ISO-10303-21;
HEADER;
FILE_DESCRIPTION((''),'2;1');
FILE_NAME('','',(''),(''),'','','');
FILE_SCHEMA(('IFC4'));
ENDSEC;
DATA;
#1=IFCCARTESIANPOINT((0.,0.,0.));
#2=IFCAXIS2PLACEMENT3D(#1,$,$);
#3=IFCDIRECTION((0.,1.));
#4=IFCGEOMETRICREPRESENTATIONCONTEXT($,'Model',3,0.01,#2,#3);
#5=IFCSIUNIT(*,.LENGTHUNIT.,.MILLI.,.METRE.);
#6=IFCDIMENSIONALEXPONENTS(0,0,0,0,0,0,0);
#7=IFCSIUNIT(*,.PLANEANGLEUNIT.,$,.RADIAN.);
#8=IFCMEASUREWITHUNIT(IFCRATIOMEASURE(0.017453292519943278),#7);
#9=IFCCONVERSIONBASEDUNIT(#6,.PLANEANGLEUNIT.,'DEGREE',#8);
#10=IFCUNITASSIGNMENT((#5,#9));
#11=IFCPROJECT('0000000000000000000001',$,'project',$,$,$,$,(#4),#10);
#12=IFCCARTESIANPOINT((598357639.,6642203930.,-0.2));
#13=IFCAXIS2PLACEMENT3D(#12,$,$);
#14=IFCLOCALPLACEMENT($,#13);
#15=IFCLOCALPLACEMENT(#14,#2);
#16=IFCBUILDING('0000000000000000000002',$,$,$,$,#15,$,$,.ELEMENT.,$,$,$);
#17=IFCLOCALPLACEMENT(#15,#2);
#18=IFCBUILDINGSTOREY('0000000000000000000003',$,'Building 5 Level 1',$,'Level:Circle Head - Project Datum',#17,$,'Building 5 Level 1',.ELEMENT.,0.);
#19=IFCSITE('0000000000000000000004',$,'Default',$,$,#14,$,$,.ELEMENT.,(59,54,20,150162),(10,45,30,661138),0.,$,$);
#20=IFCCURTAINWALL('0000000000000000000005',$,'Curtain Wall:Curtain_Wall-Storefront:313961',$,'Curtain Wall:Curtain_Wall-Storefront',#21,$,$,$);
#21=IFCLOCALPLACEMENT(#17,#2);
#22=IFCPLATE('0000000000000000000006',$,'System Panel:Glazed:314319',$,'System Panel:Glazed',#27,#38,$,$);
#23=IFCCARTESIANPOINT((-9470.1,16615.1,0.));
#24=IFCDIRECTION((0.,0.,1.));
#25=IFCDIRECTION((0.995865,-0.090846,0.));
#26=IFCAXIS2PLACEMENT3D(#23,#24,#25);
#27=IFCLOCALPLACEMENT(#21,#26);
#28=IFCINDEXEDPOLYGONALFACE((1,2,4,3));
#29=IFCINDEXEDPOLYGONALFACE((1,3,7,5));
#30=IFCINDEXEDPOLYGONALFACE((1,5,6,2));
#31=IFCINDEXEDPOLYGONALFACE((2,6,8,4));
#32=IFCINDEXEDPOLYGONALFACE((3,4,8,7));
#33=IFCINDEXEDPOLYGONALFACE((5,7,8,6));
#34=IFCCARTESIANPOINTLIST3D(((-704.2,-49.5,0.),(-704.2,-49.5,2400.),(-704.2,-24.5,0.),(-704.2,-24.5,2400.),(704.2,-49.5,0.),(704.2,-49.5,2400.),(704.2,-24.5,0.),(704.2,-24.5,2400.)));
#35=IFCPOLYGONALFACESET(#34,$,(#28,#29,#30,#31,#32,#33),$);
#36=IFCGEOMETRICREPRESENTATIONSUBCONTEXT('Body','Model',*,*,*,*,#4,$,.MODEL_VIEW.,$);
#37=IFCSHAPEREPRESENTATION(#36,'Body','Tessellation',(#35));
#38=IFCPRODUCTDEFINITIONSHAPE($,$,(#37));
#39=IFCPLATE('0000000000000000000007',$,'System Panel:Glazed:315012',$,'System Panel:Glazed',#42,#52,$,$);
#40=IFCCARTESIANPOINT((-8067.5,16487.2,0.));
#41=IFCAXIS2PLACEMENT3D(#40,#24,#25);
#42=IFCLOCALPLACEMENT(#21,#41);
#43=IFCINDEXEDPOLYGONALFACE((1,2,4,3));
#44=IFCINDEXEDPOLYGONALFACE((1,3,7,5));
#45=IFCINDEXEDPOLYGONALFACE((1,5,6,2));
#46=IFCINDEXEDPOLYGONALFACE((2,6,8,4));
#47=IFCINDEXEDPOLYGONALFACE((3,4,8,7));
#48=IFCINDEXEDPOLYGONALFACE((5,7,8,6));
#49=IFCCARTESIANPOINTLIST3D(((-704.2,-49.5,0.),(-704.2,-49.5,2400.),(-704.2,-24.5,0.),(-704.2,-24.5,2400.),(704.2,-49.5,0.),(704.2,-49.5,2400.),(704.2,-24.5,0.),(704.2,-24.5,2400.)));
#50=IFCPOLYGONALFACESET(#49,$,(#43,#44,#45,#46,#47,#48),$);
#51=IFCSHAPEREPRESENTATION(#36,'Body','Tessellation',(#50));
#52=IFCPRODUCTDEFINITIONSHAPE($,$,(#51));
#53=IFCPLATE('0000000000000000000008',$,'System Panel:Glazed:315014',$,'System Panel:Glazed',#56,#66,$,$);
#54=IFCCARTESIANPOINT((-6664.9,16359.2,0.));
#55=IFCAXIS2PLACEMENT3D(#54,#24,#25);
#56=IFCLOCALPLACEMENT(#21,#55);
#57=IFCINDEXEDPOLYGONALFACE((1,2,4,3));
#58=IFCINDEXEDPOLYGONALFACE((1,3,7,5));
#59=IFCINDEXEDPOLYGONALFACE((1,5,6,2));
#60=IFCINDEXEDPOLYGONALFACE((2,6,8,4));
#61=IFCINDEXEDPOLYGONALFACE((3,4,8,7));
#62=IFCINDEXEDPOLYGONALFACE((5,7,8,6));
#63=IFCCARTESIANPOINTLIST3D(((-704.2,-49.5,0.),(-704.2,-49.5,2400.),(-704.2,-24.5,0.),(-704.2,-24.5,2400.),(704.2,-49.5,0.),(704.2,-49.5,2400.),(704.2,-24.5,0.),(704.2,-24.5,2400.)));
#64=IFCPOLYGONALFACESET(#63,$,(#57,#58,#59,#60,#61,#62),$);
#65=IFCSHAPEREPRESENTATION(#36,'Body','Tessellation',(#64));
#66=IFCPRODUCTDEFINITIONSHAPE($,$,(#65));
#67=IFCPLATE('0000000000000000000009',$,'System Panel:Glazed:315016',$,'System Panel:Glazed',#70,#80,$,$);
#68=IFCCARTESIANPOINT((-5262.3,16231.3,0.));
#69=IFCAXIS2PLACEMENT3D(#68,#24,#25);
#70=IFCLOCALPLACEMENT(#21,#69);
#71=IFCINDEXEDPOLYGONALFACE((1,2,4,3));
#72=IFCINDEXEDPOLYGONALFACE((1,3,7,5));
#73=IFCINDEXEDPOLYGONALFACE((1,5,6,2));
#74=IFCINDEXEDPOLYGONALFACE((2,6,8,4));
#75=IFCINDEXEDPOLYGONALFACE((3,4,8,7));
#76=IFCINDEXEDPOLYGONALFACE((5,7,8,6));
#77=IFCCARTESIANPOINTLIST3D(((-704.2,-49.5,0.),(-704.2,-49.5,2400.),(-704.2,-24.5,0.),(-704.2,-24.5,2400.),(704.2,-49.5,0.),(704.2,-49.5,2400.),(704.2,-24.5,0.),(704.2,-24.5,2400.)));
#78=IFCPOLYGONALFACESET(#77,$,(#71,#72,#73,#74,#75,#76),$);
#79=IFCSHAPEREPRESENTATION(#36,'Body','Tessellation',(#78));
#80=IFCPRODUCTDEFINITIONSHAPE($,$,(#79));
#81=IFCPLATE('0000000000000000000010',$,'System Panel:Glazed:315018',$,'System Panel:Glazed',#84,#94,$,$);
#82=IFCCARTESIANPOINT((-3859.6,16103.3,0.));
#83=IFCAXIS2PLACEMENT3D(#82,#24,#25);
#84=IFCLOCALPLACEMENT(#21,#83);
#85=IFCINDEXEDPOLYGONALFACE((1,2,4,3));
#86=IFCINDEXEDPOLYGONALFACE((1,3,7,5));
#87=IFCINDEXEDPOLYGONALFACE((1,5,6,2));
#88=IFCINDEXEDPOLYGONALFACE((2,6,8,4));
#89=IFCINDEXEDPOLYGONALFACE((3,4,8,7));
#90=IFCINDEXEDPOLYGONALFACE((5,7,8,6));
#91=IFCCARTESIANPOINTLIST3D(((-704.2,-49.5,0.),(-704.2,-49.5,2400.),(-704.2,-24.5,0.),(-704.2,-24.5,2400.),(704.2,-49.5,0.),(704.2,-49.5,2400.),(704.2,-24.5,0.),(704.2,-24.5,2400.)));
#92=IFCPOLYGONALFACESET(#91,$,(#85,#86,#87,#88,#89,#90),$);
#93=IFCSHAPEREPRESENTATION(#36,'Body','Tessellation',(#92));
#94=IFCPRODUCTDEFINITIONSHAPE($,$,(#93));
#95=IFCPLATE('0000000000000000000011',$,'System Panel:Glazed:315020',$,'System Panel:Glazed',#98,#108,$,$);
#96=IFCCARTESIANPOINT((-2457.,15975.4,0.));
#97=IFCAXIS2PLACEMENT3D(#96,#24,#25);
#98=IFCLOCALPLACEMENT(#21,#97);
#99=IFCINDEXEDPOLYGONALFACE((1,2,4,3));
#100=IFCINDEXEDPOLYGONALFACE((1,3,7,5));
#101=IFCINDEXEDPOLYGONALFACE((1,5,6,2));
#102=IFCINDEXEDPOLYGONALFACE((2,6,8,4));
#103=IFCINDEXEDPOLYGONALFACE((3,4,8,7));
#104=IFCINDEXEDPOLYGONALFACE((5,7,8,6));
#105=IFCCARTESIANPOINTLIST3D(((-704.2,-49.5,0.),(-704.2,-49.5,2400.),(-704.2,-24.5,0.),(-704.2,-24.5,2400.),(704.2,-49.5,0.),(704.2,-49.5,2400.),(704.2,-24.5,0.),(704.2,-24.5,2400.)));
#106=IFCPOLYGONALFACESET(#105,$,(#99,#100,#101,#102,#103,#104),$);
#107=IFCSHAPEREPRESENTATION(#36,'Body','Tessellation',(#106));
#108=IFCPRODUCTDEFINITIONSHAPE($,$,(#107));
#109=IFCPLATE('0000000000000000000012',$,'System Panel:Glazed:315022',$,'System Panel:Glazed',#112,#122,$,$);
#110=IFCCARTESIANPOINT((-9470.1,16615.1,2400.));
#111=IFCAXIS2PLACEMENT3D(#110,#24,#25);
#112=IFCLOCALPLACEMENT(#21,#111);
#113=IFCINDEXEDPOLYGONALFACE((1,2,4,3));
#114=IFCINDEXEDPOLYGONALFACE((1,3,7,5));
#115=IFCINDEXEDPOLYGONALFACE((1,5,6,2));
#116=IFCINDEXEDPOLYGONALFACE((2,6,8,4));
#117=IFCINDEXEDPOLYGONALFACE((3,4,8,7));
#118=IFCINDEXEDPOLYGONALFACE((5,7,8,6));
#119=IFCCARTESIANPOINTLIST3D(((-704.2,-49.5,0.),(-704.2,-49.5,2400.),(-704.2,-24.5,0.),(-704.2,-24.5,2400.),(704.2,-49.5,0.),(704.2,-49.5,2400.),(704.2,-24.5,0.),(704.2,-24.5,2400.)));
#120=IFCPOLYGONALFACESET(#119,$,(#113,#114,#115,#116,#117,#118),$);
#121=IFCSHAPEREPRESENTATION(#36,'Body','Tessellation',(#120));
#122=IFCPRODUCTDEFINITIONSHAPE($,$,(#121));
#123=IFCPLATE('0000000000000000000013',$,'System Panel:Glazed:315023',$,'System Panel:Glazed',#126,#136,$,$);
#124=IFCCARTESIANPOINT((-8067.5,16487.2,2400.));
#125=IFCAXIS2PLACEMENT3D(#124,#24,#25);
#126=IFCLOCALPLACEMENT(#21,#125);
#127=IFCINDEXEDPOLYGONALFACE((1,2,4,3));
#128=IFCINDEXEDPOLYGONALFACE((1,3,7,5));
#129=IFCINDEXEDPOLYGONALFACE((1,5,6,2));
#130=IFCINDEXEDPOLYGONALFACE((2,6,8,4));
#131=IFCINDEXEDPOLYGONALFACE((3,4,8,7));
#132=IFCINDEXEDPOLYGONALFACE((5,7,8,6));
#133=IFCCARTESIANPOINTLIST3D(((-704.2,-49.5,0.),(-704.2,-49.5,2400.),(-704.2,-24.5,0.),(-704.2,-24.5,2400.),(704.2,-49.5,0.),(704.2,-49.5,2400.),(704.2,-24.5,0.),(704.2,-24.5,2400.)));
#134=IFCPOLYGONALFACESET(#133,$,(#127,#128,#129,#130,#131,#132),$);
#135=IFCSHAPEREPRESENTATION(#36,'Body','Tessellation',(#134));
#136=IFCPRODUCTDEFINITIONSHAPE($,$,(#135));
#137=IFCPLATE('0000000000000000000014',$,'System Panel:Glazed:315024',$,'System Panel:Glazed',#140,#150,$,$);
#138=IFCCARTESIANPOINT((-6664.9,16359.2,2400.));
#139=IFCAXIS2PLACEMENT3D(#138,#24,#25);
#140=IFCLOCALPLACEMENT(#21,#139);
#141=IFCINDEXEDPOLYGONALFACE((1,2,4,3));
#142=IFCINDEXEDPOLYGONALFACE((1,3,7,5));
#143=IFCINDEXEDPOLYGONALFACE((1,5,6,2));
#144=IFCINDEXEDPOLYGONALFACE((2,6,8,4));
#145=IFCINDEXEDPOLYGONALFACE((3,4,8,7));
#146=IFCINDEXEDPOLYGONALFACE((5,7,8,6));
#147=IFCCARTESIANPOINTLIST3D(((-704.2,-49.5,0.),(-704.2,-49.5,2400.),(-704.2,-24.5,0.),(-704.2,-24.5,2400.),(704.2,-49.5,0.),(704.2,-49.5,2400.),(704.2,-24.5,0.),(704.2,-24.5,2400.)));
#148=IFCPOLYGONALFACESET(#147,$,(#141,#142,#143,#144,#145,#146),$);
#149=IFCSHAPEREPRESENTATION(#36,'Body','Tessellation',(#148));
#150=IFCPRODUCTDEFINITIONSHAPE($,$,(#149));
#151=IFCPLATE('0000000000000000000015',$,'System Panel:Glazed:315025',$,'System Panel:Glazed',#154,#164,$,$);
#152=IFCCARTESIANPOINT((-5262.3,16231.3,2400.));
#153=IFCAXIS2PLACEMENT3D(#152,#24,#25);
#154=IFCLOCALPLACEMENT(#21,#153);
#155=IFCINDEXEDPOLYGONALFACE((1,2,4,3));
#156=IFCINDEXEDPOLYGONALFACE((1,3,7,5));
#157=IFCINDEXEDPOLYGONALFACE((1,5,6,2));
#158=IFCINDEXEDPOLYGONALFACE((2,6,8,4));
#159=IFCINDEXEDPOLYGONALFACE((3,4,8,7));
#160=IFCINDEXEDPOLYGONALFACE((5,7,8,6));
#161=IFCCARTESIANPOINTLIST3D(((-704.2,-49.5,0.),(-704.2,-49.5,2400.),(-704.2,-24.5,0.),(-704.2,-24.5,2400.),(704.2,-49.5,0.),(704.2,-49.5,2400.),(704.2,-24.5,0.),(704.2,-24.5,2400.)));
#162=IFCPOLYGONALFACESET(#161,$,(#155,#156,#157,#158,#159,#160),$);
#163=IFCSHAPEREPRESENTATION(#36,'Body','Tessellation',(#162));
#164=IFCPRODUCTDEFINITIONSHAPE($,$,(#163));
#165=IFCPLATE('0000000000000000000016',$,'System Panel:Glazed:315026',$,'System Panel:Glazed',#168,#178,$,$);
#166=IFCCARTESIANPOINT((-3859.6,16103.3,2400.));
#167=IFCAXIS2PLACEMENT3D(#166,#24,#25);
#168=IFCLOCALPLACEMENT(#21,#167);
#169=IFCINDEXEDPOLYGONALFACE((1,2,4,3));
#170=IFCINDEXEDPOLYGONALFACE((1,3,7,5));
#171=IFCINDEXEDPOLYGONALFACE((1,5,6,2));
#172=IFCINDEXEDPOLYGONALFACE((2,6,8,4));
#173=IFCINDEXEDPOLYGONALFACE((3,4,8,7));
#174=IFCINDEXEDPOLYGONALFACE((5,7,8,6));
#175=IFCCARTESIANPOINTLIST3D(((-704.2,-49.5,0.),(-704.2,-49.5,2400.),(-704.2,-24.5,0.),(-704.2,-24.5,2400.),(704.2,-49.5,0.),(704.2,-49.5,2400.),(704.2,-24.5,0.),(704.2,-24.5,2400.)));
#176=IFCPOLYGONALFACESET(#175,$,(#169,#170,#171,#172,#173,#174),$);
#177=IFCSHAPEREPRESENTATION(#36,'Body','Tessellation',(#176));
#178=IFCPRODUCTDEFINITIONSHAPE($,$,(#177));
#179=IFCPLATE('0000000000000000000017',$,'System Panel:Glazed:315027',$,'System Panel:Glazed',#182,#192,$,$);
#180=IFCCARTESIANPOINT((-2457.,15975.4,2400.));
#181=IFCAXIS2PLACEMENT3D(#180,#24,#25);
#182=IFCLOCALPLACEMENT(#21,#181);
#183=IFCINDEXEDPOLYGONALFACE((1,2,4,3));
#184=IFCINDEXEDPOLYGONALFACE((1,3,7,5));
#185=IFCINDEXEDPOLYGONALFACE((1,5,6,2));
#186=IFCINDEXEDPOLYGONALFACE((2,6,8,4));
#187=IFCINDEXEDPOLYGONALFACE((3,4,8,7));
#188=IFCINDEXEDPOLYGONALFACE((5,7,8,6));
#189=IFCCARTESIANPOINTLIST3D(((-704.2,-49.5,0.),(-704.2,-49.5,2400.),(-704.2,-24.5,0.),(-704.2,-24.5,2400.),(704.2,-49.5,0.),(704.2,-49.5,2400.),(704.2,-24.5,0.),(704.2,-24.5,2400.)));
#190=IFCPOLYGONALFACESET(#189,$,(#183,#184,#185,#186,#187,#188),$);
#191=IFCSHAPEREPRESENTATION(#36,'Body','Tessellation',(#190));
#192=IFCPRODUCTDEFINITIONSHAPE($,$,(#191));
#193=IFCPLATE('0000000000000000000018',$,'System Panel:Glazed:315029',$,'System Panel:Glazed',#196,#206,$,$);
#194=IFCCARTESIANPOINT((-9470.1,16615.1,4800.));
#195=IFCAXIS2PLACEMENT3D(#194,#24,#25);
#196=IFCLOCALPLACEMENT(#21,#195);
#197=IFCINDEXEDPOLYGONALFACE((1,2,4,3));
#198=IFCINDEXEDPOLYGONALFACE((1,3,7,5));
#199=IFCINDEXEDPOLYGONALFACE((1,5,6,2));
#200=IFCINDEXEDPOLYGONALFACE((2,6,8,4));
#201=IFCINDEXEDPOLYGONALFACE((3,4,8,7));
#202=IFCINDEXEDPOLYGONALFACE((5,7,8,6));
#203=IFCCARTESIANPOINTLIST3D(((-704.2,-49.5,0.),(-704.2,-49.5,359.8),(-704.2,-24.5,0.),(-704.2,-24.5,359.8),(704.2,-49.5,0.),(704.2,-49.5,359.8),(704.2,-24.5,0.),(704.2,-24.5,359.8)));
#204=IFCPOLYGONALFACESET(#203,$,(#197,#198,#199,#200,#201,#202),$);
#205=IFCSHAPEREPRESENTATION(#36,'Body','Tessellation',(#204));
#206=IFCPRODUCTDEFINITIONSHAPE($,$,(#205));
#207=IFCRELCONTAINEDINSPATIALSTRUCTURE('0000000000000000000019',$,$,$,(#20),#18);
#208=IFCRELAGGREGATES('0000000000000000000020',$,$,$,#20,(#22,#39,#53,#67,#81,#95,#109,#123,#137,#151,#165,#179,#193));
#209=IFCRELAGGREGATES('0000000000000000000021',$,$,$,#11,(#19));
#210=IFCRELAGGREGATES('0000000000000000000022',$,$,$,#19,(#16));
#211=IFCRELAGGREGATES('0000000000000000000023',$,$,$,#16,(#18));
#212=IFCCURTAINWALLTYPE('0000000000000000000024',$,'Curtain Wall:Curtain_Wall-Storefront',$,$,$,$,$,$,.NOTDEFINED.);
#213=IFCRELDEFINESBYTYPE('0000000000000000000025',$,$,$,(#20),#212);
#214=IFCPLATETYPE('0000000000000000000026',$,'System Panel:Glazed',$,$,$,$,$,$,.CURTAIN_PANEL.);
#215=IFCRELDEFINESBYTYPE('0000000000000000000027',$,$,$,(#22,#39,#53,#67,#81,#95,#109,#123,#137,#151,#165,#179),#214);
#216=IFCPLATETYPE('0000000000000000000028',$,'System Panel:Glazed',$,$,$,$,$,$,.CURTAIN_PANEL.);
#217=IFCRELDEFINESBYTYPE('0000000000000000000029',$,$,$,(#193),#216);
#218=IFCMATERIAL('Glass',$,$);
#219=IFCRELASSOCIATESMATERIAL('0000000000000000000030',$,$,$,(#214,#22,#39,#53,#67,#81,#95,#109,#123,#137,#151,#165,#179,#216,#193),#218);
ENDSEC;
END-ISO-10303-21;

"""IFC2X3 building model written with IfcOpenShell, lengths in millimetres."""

from ifc_helpers import new_model, entity, si_unit, converted_unit, direction, frame, frame_2d, origin, place, context, subcontext, project, spatial, rectangle, extrude, source, transform, mapped, material, type_object, type_shapes, element, aggregate, save


model = new_model("IFC2X3")

# Units and contexts
model_context = context("Model", 3, precision=0.01, world=origin(), true_north=direction((0.0, 1.0)))
body_context = subcontext(model_context, "Body", "Model", "MODEL_VIEW")
ifc_project = project(units=[si_unit("LENGTHUNIT", "METRE", prefix="MILLI"), converted_unit("PLANEANGLEUNIT", "DEGREE", entity("IfcRatioMeasure", 0.017453292519943278), si_unit("PLANEANGLEUNIT", "RADIAN"), dimensions=[0, 0, 0, 0, 0, 0, 0])], contexts=[model_context])

# Site, building, storey
site_placement = place(None, frame((598357639.0, 6642203930.0, -0.2)))
site = spatial("IfcSite", under=ifc_project, at=site_placement, Name="Default", CompositionType="ELEMENT", RefLatitude=(59, 54, 20, 150162), RefLongitude=(10, 45, 30, 661138), RefElevation=0.0)
building_placement = place(site_placement, origin())
building = spatial("IfcBuilding", under=site, at=building_placement, CompositionType="ELEMENT")
storey_placement = place(building_placement, origin())
storey = spatial("IfcBuildingStorey", under=building, at=storey_placement, Name="Building 5 Level 1", ObjectType="Level:Circle Head - Project Datum", LongName="Building 5 Level 1", CompositionType="ELEMENT", Elevation=0.0)

# Curtain wall, plates
curtain_wall_type = type_object("IfcCurtainWallType", Name="Curtain Wall:Curtain_Wall-Storefront", PredefinedType="NOTDEFINED")
ifc_material_1 = material(Name="Glass")
curtain_wall_1_placement = place(storey_placement, origin())
curtain_wall_1 = element("IfcCurtainWall", 1, at=curtain_wall_1_placement, inside=storey, type_object=curtain_wall_type, Name="Curtain Wall:Curtain_Wall-Storefront:313961", ObjectType="Curtain Wall:Curtain_Wall-Storefront")
plate_type_1 = type_object("IfcPlateType", Name="System Panel:Glazed", PredefinedType="CURTAIN_PANEL", material=ifc_material_1)
shared_shape_1 = source(origin(), body_context, "Body", "SweptSolid", [
    extrude(rectangle(XDim=25.0, YDim=1408.5, at=frame_2d((0.0, 0.0), x_axis=(1.0, 0.0))), frame((0.0, -37.0, 0.0), z_axis=(0.0, 0.0, 1.0), x_axis=(0.0, 1.0, 0.0)), (0.0, 0.0, 1.0), 2400.0),
])
type_shapes(plate_type_1, [shared_shape_1])
plate_1_placement = place(curtain_wall_1_placement, frame((-9470.1, 16615.1, 0.0), z_axis=(0.0, 0.0, 1.0), x_axis=(0.995865, -0.090846, 0.0)))
plate_1 = element("IfcPlate", 2, at=plate_1_placement, type_object=plate_type_1, material=ifc_material_1, Name="System Panel:Glazed:314319", ObjectType="System Panel:Glazed", context=body_context, shape_type="MappedRepresentation", body=[
    mapped(shared_shape_1, transform((0.0, 0.0, 0.0), scale=1.0)),
])
plate_2_placement = place(curtain_wall_1_placement, frame((-8067.5, 16487.2, 0.0), z_axis=(0.0, 0.0, 1.0), x_axis=(0.995865, -0.090846, 0.0)))
plate_2 = element("IfcPlate", 3, at=plate_2_placement, type_object=plate_type_1, material=ifc_material_1, Name="System Panel:Glazed:315012", ObjectType="System Panel:Glazed", context=body_context, shape_type="MappedRepresentation", body=[
    mapped(shared_shape_1, transform((0.0, 0.0, 0.0), scale=1.0)),
])
plate_3_placement = place(curtain_wall_1_placement, frame((-6664.9, 16359.2, 0.0), z_axis=(0.0, 0.0, 1.0), x_axis=(0.995865, -0.090846, 0.0)))
plate_3 = element("IfcPlate", 4, at=plate_3_placement, type_object=plate_type_1, material=ifc_material_1, Name="System Panel:Glazed:315014", ObjectType="System Panel:Glazed", context=body_context, shape_type="MappedRepresentation", body=[
    mapped(shared_shape_1, transform((0.0, 0.0, 0.0), scale=1.0)),
])
plate_4_placement = place(curtain_wall_1_placement, frame((-5262.3, 16231.3, 0.0), z_axis=(0.0, 0.0, 1.0), x_axis=(0.995865, -0.090846, 0.0)))
plate_4 = element("IfcPlate", 5, at=plate_4_placement, type_object=plate_type_1, material=ifc_material_1, Name="System Panel:Glazed:315016", ObjectType="System Panel:Glazed", context=body_context, shape_type="MappedRepresentation", body=[
    mapped(shared_shape_1, transform((0.0, 0.0, 0.0), scale=1.0)),
])
plate_5_placement = place(curtain_wall_1_placement, frame((-3859.6, 16103.3, 0.0), z_axis=(0.0, 0.0, 1.0), x_axis=(0.995865, -0.090846, 0.0)))
plate_5 = element("IfcPlate", 6, at=plate_5_placement, type_object=plate_type_1, material=ifc_material_1, Name="System Panel:Glazed:315018", ObjectType="System Panel:Glazed", context=body_context, shape_type="MappedRepresentation", body=[
    mapped(shared_shape_1, transform((0.0, 0.0, 0.0), scale=1.0)),
])
plate_6_placement = place(curtain_wall_1_placement, frame((-2457.0, 15975.4, 0.0), z_axis=(0.0, 0.0, 1.0), x_axis=(0.995865, -0.090846, 0.0)))
plate_6 = element("IfcPlate", 7, at=plate_6_placement, type_object=plate_type_1, material=ifc_material_1, Name="System Panel:Glazed:315020", ObjectType="System Panel:Glazed", context=body_context, shape_type="MappedRepresentation", body=[
    mapped(shared_shape_1, transform((0.0, 0.0, 0.0), scale=1.0)),
])
plate_7_placement = place(curtain_wall_1_placement, frame((-9470.1, 16615.1, 2400.0), z_axis=(0.0, 0.0, 1.0), x_axis=(0.995865, -0.090846, 0.0)))
plate_7 = element("IfcPlate", 8, at=plate_7_placement, type_object=plate_type_1, material=ifc_material_1, Name="System Panel:Glazed:315022", ObjectType="System Panel:Glazed", context=body_context, shape_type="MappedRepresentation", body=[
    mapped(shared_shape_1, transform((0.0, 0.0, 0.0), scale=1.0)),
])
plate_8_placement = place(curtain_wall_1_placement, frame((-8067.5, 16487.2, 2400.0), z_axis=(0.0, 0.0, 1.0), x_axis=(0.995865, -0.090846, 0.0)))
plate_8 = element("IfcPlate", 9, at=plate_8_placement, type_object=plate_type_1, material=ifc_material_1, Name="System Panel:Glazed:315023", ObjectType="System Panel:Glazed", context=body_context, shape_type="MappedRepresentation", body=[
    mapped(shared_shape_1, transform((0.0, 0.0, 0.0), scale=1.0)),
])
plate_9_placement = place(curtain_wall_1_placement, frame((-6664.9, 16359.2, 2400.0), z_axis=(0.0, 0.0, 1.0), x_axis=(0.995865, -0.090846, 0.0)))
plate_9 = element("IfcPlate", 10, at=plate_9_placement, type_object=plate_type_1, material=ifc_material_1, Name="System Panel:Glazed:315024", ObjectType="System Panel:Glazed", context=body_context, shape_type="MappedRepresentation", body=[
    mapped(shared_shape_1, transform((0.0, 0.0, 0.0), scale=1.0)),
])
plate_10_placement = place(curtain_wall_1_placement, frame((-5262.3, 16231.3, 2400.0), z_axis=(0.0, 0.0, 1.0), x_axis=(0.995865, -0.090846, 0.0)))
plate_10 = element("IfcPlate", 11, at=plate_10_placement, type_object=plate_type_1, material=ifc_material_1, Name="System Panel:Glazed:315025", ObjectType="System Panel:Glazed", context=body_context, shape_type="MappedRepresentation", body=[
    mapped(shared_shape_1, transform((0.0, 0.0, 0.0), scale=1.0)),
])
plate_11_placement = place(curtain_wall_1_placement, frame((-3859.6, 16103.3, 2400.0), z_axis=(0.0, 0.0, 1.0), x_axis=(0.995865, -0.090846, 0.0)))
plate_11 = element("IfcPlate", 12, at=plate_11_placement, type_object=plate_type_1, material=ifc_material_1, Name="System Panel:Glazed:315026", ObjectType="System Panel:Glazed", context=body_context, shape_type="MappedRepresentation", body=[
    mapped(shared_shape_1, transform((0.0, 0.0, 0.0), scale=1.0)),
])
plate_12_placement = place(curtain_wall_1_placement, frame((-2457.0, 15975.4, 2400.0), z_axis=(0.0, 0.0, 1.0), x_axis=(0.995865, -0.090846, 0.0)))
plate_12 = element("IfcPlate", 13, at=plate_12_placement, type_object=plate_type_1, material=ifc_material_1, Name="System Panel:Glazed:315027", ObjectType="System Panel:Glazed", context=body_context, shape_type="MappedRepresentation", body=[
    mapped(shared_shape_1, transform((0.0, 0.0, 0.0), scale=1.0)),
])
plate_type_2 = type_object("IfcPlateType", Name="System Panel:Glazed", PredefinedType="CURTAIN_PANEL", material=ifc_material_1)
shared_shape_2 = source(origin(), body_context, "Body", "SweptSolid", [
    extrude(rectangle(XDim=25.0, YDim=1408.5, at=frame_2d((0.0, 0.0), x_axis=(1.0, 0.0))), frame((0.0, -37.0, 0.0), z_axis=(0.0, 0.0, 1.0), x_axis=(0.0, 1.0, 0.0)), (0.0, 0.0, 1.0), 359.8),
])
type_shapes(plate_type_2, [shared_shape_2])
plate_13_placement = place(curtain_wall_1_placement, frame((-9470.1, 16615.1, 4800.0), z_axis=(0.0, 0.0, 1.0), x_axis=(0.995865, -0.090846, 0.0)))
plate_13 = element("IfcPlate", 14, at=plate_13_placement, type_object=plate_type_2, material=ifc_material_1, Name="System Panel:Glazed:315029", ObjectType="System Panel:Glazed", context=body_context, shape_type="MappedRepresentation", body=[
    mapped(shared_shape_2, transform((0.0, 0.0, 0.0), scale=1.0)),
])
aggregate(curtain_wall_1, [plate_1, plate_2, plate_3, plate_4, plate_5, plate_6, plate_7, plate_8, plate_9, plate_10, plate_11, plate_12, plate_13])

save(model, "model.ifc")
